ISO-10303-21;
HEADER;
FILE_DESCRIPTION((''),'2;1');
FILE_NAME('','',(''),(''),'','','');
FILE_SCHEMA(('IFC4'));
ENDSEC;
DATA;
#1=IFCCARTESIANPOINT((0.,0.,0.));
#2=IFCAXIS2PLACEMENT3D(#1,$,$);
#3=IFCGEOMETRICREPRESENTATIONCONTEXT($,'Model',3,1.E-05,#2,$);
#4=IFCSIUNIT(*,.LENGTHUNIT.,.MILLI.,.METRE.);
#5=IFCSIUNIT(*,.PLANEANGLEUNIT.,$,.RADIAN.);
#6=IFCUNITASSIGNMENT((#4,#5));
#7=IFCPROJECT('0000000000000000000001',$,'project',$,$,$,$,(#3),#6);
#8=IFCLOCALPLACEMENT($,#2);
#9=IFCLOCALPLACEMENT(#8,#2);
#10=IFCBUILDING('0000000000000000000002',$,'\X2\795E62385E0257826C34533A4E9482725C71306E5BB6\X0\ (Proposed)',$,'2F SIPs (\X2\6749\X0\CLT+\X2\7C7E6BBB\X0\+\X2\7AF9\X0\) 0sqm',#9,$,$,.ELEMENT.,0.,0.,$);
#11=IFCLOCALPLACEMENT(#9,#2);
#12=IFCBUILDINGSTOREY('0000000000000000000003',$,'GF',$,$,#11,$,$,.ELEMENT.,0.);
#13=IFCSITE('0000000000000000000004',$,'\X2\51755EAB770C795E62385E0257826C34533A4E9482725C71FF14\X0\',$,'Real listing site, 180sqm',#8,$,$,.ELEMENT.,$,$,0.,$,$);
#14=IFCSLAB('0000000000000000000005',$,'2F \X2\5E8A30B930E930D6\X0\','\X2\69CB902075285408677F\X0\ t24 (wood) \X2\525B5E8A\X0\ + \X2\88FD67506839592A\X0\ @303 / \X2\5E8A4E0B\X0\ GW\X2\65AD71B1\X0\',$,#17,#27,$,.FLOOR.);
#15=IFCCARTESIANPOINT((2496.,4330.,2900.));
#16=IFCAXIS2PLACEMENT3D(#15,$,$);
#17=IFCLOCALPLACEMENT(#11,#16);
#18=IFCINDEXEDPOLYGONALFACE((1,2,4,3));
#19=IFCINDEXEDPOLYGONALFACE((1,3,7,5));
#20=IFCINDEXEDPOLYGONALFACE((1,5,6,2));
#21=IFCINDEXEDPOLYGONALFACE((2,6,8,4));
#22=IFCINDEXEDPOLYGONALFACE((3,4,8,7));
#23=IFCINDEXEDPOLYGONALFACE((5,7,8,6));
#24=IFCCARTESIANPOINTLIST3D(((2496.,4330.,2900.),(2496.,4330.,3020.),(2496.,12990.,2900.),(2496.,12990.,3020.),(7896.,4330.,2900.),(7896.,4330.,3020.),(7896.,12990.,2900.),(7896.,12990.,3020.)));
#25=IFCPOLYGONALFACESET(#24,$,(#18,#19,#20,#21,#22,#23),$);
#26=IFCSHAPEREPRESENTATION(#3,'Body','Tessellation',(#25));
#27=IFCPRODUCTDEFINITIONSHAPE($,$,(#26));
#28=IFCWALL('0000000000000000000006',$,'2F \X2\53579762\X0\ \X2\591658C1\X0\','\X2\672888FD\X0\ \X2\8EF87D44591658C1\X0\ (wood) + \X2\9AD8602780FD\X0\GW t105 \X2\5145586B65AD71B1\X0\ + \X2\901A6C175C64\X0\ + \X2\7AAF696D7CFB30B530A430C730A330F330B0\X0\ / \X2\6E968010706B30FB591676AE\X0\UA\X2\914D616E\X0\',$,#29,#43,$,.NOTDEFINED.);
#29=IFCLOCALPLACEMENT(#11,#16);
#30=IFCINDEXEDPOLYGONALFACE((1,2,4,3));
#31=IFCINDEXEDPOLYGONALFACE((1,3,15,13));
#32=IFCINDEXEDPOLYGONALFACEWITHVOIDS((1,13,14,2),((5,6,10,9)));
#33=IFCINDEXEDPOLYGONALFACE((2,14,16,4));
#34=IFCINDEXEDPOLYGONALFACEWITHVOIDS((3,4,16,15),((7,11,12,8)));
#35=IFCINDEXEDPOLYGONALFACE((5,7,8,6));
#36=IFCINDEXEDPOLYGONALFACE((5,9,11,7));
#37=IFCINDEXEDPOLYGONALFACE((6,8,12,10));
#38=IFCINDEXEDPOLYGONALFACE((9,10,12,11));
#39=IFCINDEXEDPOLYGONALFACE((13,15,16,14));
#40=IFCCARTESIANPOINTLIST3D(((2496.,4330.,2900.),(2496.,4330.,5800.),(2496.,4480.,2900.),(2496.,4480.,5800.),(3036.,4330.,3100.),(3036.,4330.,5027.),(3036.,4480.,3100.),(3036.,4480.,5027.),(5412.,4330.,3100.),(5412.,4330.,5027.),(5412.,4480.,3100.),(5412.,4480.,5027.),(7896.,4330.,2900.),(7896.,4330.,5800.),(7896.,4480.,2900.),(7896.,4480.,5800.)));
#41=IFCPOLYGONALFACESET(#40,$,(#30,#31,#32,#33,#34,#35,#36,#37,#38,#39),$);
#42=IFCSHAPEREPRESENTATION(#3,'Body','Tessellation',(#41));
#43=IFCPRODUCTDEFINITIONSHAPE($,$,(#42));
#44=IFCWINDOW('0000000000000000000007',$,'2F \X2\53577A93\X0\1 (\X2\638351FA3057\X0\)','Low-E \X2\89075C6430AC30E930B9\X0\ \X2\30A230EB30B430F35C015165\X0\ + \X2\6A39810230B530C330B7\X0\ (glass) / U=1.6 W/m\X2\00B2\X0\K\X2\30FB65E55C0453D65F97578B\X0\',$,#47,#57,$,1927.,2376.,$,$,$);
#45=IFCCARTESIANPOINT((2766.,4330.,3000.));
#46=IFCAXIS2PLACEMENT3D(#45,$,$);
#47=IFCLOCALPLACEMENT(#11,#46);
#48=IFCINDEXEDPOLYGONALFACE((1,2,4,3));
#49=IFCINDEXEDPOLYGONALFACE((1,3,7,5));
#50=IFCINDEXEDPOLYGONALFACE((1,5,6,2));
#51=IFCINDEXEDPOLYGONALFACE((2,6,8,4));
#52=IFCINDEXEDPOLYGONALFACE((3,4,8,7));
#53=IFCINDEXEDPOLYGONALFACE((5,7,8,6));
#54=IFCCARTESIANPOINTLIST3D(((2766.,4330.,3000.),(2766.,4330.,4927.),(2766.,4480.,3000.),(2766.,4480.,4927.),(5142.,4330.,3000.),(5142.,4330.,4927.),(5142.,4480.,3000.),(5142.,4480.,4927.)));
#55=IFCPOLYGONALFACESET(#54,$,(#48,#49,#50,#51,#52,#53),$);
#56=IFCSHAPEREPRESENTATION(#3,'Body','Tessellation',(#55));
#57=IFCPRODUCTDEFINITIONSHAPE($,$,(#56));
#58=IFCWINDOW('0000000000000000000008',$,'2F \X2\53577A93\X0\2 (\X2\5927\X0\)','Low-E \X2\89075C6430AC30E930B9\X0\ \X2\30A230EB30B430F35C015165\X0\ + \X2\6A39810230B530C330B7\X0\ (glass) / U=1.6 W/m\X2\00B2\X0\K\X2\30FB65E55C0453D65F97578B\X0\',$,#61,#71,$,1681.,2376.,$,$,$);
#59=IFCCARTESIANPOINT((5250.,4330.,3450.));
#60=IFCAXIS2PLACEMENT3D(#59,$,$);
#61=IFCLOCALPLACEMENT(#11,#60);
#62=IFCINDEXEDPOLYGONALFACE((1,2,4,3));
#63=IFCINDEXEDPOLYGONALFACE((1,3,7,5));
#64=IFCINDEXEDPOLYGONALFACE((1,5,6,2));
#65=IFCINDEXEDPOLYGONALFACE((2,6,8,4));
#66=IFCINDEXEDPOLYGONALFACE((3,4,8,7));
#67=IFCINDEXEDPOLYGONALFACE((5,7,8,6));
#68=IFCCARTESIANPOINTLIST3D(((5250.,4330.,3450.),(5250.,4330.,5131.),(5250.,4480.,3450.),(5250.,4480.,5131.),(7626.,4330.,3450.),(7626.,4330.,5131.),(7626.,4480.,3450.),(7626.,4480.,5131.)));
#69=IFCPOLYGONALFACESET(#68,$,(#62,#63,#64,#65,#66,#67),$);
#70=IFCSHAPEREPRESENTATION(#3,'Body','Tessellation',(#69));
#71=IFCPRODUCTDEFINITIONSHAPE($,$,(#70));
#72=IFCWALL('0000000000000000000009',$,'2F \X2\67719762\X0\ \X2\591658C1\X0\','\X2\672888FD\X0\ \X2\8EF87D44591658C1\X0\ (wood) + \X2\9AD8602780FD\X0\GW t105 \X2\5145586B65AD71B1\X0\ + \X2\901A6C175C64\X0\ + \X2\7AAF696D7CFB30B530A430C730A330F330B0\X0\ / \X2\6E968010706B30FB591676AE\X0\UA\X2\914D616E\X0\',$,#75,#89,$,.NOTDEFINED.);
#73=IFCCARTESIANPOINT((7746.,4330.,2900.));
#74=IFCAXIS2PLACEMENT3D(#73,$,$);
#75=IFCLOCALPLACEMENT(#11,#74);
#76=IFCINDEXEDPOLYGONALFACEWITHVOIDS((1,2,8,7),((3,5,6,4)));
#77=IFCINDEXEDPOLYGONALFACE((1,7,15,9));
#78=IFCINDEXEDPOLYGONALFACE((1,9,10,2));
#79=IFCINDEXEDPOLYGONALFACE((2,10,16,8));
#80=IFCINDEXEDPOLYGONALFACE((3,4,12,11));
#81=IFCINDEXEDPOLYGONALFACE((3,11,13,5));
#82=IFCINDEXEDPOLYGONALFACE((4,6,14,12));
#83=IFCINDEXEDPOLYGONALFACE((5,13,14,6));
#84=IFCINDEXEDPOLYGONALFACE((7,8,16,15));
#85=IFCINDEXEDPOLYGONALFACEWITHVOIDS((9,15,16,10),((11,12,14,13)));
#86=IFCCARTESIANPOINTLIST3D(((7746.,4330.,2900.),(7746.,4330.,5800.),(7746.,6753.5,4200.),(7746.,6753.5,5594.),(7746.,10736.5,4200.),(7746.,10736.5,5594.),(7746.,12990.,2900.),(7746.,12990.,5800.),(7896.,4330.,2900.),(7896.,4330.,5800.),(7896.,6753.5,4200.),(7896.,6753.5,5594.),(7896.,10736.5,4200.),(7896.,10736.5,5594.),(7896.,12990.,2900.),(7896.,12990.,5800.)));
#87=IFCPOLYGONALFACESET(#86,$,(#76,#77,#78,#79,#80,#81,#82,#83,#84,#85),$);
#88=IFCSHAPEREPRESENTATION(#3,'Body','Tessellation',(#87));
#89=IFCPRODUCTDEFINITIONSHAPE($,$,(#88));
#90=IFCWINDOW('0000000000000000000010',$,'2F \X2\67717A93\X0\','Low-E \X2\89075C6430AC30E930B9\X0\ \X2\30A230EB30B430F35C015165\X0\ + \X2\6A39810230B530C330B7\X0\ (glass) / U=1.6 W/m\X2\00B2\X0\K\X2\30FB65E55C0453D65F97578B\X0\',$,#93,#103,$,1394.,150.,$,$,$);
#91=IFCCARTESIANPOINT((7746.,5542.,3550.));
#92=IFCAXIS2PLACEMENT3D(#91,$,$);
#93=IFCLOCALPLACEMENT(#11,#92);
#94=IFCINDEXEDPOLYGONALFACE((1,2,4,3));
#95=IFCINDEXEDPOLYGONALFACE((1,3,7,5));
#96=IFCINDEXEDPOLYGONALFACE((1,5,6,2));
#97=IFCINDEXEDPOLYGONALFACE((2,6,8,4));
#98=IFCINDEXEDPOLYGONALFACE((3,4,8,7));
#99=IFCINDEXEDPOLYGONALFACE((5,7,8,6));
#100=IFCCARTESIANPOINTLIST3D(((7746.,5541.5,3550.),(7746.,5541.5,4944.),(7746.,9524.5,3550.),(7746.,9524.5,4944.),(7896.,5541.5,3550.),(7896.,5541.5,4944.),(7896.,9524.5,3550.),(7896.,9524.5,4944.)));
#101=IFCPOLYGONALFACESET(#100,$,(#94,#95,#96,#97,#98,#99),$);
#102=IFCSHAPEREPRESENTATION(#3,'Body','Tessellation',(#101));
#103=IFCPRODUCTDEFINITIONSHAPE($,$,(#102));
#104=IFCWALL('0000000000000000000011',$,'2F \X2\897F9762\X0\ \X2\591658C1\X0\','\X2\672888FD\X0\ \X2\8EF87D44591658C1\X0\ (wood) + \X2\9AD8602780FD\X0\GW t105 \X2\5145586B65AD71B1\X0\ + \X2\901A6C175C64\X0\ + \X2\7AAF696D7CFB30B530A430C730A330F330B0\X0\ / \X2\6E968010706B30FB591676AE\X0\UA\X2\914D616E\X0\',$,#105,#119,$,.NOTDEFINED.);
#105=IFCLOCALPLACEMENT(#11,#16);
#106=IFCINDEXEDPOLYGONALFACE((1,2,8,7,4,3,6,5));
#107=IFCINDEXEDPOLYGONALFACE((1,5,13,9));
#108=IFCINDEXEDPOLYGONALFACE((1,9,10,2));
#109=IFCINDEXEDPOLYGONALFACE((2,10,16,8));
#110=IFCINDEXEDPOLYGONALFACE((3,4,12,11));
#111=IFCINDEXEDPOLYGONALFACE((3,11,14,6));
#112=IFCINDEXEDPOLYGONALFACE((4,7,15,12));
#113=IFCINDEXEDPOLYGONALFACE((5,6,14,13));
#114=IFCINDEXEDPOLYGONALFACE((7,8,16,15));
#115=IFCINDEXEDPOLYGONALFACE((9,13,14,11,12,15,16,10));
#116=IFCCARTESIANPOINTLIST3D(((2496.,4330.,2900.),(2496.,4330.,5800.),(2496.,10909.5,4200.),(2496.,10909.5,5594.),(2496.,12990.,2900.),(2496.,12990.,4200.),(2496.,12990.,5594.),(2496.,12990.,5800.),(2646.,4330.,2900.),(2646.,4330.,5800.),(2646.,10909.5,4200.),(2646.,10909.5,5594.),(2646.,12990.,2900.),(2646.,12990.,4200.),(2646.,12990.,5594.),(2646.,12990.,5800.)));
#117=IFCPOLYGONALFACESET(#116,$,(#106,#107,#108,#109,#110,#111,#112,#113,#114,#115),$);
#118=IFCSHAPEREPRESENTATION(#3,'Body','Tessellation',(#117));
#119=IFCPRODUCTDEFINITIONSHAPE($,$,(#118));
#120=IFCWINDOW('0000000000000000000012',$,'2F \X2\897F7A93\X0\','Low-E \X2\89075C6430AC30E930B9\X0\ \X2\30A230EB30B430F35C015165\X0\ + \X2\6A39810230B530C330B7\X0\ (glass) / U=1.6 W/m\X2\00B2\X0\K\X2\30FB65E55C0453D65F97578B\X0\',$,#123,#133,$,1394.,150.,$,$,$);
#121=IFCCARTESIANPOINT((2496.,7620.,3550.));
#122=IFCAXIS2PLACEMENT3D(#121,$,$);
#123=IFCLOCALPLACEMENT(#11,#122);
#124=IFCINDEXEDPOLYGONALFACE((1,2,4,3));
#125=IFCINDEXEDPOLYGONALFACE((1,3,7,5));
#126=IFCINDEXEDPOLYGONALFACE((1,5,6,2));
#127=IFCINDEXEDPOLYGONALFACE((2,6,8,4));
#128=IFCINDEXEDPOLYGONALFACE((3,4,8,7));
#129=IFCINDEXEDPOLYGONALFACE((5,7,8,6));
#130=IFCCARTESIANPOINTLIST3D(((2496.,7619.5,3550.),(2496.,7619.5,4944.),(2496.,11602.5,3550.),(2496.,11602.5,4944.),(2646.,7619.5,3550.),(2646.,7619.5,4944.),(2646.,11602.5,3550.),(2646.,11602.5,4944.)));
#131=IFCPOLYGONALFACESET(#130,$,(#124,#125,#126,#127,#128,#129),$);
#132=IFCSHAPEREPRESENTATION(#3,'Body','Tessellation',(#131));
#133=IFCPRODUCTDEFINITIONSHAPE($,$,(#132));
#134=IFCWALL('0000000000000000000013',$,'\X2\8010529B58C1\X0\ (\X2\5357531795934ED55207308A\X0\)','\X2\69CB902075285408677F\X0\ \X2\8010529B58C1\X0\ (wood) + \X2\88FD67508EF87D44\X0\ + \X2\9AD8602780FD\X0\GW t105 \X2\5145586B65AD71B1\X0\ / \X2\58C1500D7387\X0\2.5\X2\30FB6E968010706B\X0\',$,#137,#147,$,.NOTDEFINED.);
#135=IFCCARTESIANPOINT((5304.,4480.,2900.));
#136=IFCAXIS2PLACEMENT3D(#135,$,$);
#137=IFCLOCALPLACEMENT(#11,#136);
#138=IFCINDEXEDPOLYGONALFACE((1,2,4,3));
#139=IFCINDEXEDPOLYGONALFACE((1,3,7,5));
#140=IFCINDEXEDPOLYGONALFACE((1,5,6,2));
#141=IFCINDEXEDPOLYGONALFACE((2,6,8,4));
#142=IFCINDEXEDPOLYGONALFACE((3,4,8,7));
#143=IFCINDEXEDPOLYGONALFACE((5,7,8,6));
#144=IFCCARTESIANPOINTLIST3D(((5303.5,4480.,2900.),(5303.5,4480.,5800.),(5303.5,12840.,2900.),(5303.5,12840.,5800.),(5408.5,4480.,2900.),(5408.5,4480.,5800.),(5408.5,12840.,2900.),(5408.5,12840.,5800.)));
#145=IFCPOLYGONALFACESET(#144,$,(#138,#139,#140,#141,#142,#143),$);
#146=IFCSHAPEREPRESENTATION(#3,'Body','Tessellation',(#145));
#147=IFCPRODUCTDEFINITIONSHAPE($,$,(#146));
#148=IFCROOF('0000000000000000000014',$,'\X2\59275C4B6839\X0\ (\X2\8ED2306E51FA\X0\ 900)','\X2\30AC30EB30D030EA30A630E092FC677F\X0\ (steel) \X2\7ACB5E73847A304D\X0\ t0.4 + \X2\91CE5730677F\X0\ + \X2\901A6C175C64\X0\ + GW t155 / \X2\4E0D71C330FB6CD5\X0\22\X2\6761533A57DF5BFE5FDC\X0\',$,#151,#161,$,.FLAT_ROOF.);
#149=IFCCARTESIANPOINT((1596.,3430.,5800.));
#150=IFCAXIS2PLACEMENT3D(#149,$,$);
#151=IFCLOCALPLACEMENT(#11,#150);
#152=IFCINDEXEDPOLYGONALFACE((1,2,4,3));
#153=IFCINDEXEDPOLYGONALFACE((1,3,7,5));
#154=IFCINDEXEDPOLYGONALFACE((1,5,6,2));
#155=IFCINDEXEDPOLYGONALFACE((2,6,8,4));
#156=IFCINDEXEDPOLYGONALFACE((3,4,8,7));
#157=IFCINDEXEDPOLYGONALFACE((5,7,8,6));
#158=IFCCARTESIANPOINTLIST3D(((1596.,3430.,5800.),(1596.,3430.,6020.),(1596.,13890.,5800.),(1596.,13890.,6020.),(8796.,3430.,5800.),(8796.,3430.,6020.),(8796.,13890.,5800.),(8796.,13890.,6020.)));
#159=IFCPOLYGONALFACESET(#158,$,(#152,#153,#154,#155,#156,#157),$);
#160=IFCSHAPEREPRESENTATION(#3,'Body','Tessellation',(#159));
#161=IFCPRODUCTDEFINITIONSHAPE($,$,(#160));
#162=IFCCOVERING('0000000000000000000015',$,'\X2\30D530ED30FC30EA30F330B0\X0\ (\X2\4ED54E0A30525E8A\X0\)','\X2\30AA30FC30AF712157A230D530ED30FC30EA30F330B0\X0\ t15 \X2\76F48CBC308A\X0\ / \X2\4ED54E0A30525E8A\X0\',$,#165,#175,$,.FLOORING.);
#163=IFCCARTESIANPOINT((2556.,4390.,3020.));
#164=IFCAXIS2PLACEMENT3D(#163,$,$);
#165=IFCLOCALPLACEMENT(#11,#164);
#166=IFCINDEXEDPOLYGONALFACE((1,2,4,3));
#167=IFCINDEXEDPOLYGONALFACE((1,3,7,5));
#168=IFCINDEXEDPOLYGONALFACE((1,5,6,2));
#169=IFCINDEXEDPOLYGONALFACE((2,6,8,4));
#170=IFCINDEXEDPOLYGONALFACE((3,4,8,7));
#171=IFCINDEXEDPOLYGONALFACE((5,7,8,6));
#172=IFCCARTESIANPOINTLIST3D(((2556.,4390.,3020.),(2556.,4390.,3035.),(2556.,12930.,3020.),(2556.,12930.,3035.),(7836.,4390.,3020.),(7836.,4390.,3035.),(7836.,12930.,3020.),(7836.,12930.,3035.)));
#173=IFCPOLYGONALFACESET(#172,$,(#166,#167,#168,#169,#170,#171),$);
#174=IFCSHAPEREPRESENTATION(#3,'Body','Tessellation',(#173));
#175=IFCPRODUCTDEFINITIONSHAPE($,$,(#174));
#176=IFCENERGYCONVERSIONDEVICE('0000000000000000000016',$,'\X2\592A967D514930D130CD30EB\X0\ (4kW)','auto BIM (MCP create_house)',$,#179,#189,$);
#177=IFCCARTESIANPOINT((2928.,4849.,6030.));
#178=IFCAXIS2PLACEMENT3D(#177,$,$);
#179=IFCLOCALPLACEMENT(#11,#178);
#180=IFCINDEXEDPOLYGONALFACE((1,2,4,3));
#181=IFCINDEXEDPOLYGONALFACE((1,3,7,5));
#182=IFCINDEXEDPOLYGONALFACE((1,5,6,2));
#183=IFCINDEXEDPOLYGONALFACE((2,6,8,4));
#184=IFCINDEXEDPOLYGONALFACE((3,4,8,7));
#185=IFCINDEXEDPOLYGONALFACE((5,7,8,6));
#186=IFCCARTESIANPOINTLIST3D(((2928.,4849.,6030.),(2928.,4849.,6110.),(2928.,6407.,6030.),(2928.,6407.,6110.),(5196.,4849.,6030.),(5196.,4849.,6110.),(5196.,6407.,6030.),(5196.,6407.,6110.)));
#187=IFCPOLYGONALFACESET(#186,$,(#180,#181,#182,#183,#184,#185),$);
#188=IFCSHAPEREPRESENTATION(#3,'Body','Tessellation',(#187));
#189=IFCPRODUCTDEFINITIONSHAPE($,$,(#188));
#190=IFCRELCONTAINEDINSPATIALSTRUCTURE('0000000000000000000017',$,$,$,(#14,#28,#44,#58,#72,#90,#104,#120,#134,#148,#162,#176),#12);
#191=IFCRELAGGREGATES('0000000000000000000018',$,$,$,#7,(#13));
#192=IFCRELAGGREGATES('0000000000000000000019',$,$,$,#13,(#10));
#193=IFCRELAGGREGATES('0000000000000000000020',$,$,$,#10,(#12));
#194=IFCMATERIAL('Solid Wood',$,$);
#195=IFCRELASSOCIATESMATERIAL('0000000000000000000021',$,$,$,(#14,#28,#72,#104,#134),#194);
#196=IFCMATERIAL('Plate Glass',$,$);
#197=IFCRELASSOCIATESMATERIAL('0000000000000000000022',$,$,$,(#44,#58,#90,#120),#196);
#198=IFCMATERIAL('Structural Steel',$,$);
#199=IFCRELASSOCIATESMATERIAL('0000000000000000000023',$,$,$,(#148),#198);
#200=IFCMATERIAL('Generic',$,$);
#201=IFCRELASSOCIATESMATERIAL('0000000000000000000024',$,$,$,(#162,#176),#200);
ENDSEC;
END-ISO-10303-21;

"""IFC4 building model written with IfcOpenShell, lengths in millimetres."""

from ifc_helpers import new_model, si_unit, frame, frame_2d, origin, place, context, project, spatial, rectangle, extrude, material, element, fill, save


model = new_model("IFC4")

# Units and contexts
model_context = context("Model", 3, precision=1e-05, world=origin())
ifc_project = project(units=[si_unit("LENGTHUNIT", "METRE", prefix="MILLI"), si_unit("PLANEANGLEUNIT", "RADIAN")], contexts=[model_context])

# Site, building, storey
site_placement = place(None, origin())
site = spatial("IfcSite", under=ifc_project, at=site_placement, Name="兵庫県神戸市垂水区五色山４", ObjectType="Real listing site, 180sqm", CompositionType="ELEMENT", RefElevation=0.0)
building_placement = place(site_placement, origin())
building = spatial("IfcBuilding", under=site, at=building_placement, Name="神戸市垂水区五色山の家 (Proposed)", ObjectType="2F SIPs (杉CLT+籾殻+竹) 0sqm", CompositionType="ELEMENT", ElevationOfRefHeight=0.0, ElevationOfTerrain=0.0)
storey_placement = place(building_placement, origin())
storey = spatial("IfcBuildingStorey", under=building, at=storey_placement, Name="GF", CompositionType="ELEMENT", Elevation=0.0)

# Slab
ifc_material_1 = material(Name="Solid Wood")
slab_placement = place(storey_placement, frame((2496.0, 4330.0, 2900.0)))
element("IfcSlab", 1, at=slab_placement, inside=storey, material=ifc_material_1, Name="2F 床スラブ", Description="構造用合板 t24 (wood) 剛床 + 製材根太 @303 / 床下 GW断熱", PredefinedType="FLOOR", context=model_context, shape_type="SweptSolid", body=[
    extrude(rectangle(XDim=5400.0, YDim=8660.0, at=frame_2d((2700.0, 4330.0))), frame((2496.0, 4330.0, 2900.0)), (0.0, 0.0, 1.0), 120.0),
])

# Wall, openings, windows
wall_1_placement = place(storey_placement, frame((2496.0, 4330.0, 2900.0)))
wall_1 = element("IfcWall", 2, at=wall_1_placement, inside=storey, material=ifc_material_1, Name="2F 南面 外壁", Description="木製 軸組外壁 (wood) + 高性能GW t105 充填断熱 + 通気層 + 窯業系サイディング / 準耐火・外皮UA配慮", PredefinedType="NOTDEFINED", context=model_context, shape_type="SweptSolid", body=[
    extrude(rectangle(XDim=5400.0, YDim=150.0, at=frame_2d((2700.0, 75.0))), frame((2496.0, 4330.0, 2900.0)), (0.0, 0.0, 1.0), 2900.0),
])
opening_1_placement = place(storey_placement, frame((2766.0, 4330.0, 3000.0)))
opening_1 = element("IfcOpeningElement", 3, at=opening_1_placement, cuts=wall_1, PredefinedType="NOTDEFINED", context=model_context, shape_type="SweptSolid", body=[
    extrude(rectangle(XDim=2376.0, YDim=150.0, at=frame_2d((1188.0, 75.0))), frame((2766.0, 4330.0, 3000.0)), (0.0, 0.0, 1.0), 1927.0),
])
opening_2_placement = place(storey_placement, frame((5250.0, 4330.0, 3450.0)))
opening_2 = element("IfcOpeningElement", 4, at=opening_2_placement, cuts=wall_1, PredefinedType="NOTDEFINED", context=model_context, shape_type="SweptSolid", body=[
    extrude(rectangle(XDim=2376.0, YDim=150.0, at=frame_2d((1188.0, 75.0))), frame((5250.0, 4330.0, 3450.0)), (0.0, 0.0, 1.0), 1681.0),
])
ifc_material_2 = material(Name="Plate Glass")
window_1_placement = place(storey_placement, frame((2766.0, 4330.0, 3000.0)))
window_1 = element("IfcWindow", 5, at=window_1_placement, inside=storey, material=ifc_material_2, Name="2F 南窓1 (掃出し)", Description="Low-E 複層ガラス アルゴン封入 + 樹脂サッシ (glass) / U=1.6 W/m²K・日射取得型", OverallHeight=1927.0, OverallWidth=2376.0, context=model_context, shape_type="SweptSolid", body=[
    extrude(rectangle(XDim=2376.0, YDim=150.0, at=frame_2d((1188.0, 75.0))), frame((2766.0, 4330.0, 3000.0)), (0.0, 0.0, 1.0), 1927.0),
])
fill(opening_1, window_1)
window_2_placement = place(storey_placement, frame((5250.0, 4330.0, 3450.0)))
window_2 = element("IfcWindow", 6, at=window_2_placement, inside=storey, material=ifc_material_2, Name="2F 南窓2 (大)", Description="Low-E 複層ガラス アルゴン封入 + 樹脂サッシ (glass) / U=1.6 W/m²K・日射取得型", OverallHeight=1681.0, OverallWidth=2376.0, context=model_context, shape_type="SweptSolid", body=[
    extrude(rectangle(XDim=2376.0, YDim=150.0, at=frame_2d((1188.0, 75.0))), frame((5250.0, 4330.0, 3450.0)), (0.0, 0.0, 1.0), 1681.0),
])
fill(opening_2, window_2)

# Walls, openings, windows
wall_2_placement = place(storey_placement, frame((7746.0, 4330.0, 2900.0)))
wall_2 = element("IfcWall", 7, at=wall_2_placement, inside=storey, material=ifc_material_1, Name="2F 東面 外壁", Description="木製 軸組外壁 (wood) + 高性能GW t105 充填断熱 + 通気層 + 窯業系サイディング / 準耐火・外皮UA配慮", PredefinedType="NOTDEFINED", context=model_context, shape_type="SweptSolid", body=[
    extrude(rectangle(XDim=150.0, YDim=8660.0, at=frame_2d((75.0, 4330.0))), frame((7746.0, 4330.0, 2900.0)), (0.0, 0.0, 1.0), 2900.0),
])
opening_3_placement = place(storey_placement, frame((7746.0, 5542.0, 3550.0)))
opening_3 = element("IfcOpeningElement", 8, at=opening_3_placement, cuts=wall_2, PredefinedType="NOTDEFINED", context=model_context, shape_type="SweptSolid", body=[
    extrude(rectangle(XDim=150.0, YDim=3983.0, at=frame_2d((75.0, 1991.0))), frame((7746.0, 5542.0, 3550.0)), (0.0, 0.0, 1.0), 1394.0),
])
window_3_placement = place(storey_placement, frame((7746.0, 5542.0, 3550.0)))
window_3 = element("IfcWindow", 9, at=window_3_placement, inside=storey, material=ifc_material_2, Name="2F 東窓", Description="Low-E 複層ガラス アルゴン封入 + 樹脂サッシ (glass) / U=1.6 W/m²K・日射取得型", OverallHeight=1394.0, OverallWidth=150.0, context=model_context, shape_type="SweptSolid", body=[
    extrude(rectangle(XDim=150.0, YDim=3983.0, at=frame_2d((75.0, 1991.0))), frame((7746.0, 5542.0, 3550.0)), (0.0, 0.0, 1.0), 1394.0),
])
fill(opening_3, window_3)
wall_3_placement = place(storey_placement, frame((2496.0, 4330.0, 2900.0)))
wall_3 = element("IfcWall", 10, at=wall_3_placement, inside=storey, material=ifc_material_1, Name="2F 西面 外壁", Description="木製 軸組外壁 (wood) + 高性能GW t105 充填断熱 + 通気層 + 窯業系サイディング / 準耐火・外皮UA配慮", PredefinedType="NOTDEFINED", context=model_context, shape_type="SweptSolid", body=[
    extrude(rectangle(XDim=150.0, YDim=8660.0, at=frame_2d((75.0, 4330.0))), frame((2496.0, 4330.0, 2900.0)), (0.0, 0.0, 1.0), 2900.0),
])
opening_4_placement = place(storey_placement, frame((2496.0, 7620.0, 3550.0)))
opening_4 = element("IfcOpeningElement", 11, at=opening_4_placement, cuts=wall_3, PredefinedType="NOTDEFINED", context=model_context, shape_type="SweptSolid", body=[
    extrude(rectangle(XDim=150.0, YDim=3983.0, at=frame_2d((75.0, 1991.0))), frame((2496.0, 7620.0, 3550.0)), (0.0, 0.0, 1.0), 1394.0),
])
window_4_placement = place(storey_placement, frame((2496.0, 7620.0, 3550.0)))
window_4 = element("IfcWindow", 12, at=window_4_placement, inside=storey, material=ifc_material_2, Name="2F 西窓", Description="Low-E 複層ガラス アルゴン封入 + 樹脂サッシ (glass) / U=1.6 W/m²K・日射取得型", OverallHeight=1394.0, OverallWidth=150.0, context=model_context, shape_type="SweptSolid", body=[
    extrude(rectangle(XDim=150.0, YDim=3983.0, at=frame_2d((75.0, 1991.0))), frame((2496.0, 7620.0, 3550.0)), (0.0, 0.0, 1.0), 1394.0),
])
fill(opening_4, window_4)

# Wall
wall_4_placement = place(storey_placement, frame((5304.0, 4480.0, 2900.0)))
element("IfcWall", 13, at=wall_4_placement, inside=storey, material=ifc_material_1, Name="耐力壁 (南北間仕切り)", Description="構造用合板 耐力壁 (wood) + 製材軸組 + 高性能GW t105 充填断熱 / 壁倍率2.5・準耐火", PredefinedType="NOTDEFINED", context=model_context, shape_type="SweptSolid", body=[
    extrude(rectangle(XDim=105.0, YDim=8360.0, at=frame_2d((52.0, 4180.0))), frame((5304.0, 4480.0, 2900.0)), (0.0, 0.0, 1.0), 2900.0),
])

# Roof
ifc_material_3 = material(Name="Structural Steel")
roof_placement = place(storey_placement, frame((1596.0, 3430.0, 5800.0)))
element("IfcRoof", 14, at=roof_placement, inside=storey, material=ifc_material_3, Name="大屋根 (軒の出 900)", Description="ガルバリウム鋼板 (steel) 立平葺き t0.4 + 野地板 + 通気層 + GW t155 / 不燃・法22条区域対応", PredefinedType="FLAT_ROOF", context=model_context, shape_type="SweptSolid", body=[
    extrude(rectangle(XDim=7200.0, YDim=10460.0, at=frame_2d((3600.0, 5230.0))), frame((1596.0, 3430.0, 5800.0)), (0.0, 0.0, 1.0), 220.0),
])

# Covering
ifc_material_4 = material(Name="Generic")
covering_placement = place(storey_placement, frame((2556.0, 4390.0, 3020.0)))
element("IfcCovering", 15, at=covering_placement, inside=storey, material=ifc_material_4, Name="フローリング (仕上げ床)", Description="オーク無垢フローリング t15 直貼り / 仕上げ床", PredefinedType="FLOORING", context=model_context, shape_type="SweptSolid", body=[
    extrude(rectangle(XDim=5280.0, YDim=8540.0, at=frame_2d((2640.0, 4270.0))), frame((2556.0, 4390.0, 3020.0)), (0.0, 0.0, 1.0), 15.0),
])

# Energy conversion device
energy_conversion_device_placement = place(storey_placement, frame((2928.0, 4849.0, 6030.0)))
element("IfcEnergyConversionDevice", 16, at=energy_conversion_device_placement, inside=storey, material=ifc_material_4, Name="太陽光パネル (4kW)", Description="auto BIM (MCP create_house)", context=model_context, shape_type="SweptSolid", body=[
    extrude(rectangle(XDim=2268.0, YDim=1558.0, at=frame_2d((1134.0, 779.0))), frame((2928.0, 4849.0, 6030.0)), (0.0, 0.0, 1.0), 80.0),
])

save(model, "model.ifc")
